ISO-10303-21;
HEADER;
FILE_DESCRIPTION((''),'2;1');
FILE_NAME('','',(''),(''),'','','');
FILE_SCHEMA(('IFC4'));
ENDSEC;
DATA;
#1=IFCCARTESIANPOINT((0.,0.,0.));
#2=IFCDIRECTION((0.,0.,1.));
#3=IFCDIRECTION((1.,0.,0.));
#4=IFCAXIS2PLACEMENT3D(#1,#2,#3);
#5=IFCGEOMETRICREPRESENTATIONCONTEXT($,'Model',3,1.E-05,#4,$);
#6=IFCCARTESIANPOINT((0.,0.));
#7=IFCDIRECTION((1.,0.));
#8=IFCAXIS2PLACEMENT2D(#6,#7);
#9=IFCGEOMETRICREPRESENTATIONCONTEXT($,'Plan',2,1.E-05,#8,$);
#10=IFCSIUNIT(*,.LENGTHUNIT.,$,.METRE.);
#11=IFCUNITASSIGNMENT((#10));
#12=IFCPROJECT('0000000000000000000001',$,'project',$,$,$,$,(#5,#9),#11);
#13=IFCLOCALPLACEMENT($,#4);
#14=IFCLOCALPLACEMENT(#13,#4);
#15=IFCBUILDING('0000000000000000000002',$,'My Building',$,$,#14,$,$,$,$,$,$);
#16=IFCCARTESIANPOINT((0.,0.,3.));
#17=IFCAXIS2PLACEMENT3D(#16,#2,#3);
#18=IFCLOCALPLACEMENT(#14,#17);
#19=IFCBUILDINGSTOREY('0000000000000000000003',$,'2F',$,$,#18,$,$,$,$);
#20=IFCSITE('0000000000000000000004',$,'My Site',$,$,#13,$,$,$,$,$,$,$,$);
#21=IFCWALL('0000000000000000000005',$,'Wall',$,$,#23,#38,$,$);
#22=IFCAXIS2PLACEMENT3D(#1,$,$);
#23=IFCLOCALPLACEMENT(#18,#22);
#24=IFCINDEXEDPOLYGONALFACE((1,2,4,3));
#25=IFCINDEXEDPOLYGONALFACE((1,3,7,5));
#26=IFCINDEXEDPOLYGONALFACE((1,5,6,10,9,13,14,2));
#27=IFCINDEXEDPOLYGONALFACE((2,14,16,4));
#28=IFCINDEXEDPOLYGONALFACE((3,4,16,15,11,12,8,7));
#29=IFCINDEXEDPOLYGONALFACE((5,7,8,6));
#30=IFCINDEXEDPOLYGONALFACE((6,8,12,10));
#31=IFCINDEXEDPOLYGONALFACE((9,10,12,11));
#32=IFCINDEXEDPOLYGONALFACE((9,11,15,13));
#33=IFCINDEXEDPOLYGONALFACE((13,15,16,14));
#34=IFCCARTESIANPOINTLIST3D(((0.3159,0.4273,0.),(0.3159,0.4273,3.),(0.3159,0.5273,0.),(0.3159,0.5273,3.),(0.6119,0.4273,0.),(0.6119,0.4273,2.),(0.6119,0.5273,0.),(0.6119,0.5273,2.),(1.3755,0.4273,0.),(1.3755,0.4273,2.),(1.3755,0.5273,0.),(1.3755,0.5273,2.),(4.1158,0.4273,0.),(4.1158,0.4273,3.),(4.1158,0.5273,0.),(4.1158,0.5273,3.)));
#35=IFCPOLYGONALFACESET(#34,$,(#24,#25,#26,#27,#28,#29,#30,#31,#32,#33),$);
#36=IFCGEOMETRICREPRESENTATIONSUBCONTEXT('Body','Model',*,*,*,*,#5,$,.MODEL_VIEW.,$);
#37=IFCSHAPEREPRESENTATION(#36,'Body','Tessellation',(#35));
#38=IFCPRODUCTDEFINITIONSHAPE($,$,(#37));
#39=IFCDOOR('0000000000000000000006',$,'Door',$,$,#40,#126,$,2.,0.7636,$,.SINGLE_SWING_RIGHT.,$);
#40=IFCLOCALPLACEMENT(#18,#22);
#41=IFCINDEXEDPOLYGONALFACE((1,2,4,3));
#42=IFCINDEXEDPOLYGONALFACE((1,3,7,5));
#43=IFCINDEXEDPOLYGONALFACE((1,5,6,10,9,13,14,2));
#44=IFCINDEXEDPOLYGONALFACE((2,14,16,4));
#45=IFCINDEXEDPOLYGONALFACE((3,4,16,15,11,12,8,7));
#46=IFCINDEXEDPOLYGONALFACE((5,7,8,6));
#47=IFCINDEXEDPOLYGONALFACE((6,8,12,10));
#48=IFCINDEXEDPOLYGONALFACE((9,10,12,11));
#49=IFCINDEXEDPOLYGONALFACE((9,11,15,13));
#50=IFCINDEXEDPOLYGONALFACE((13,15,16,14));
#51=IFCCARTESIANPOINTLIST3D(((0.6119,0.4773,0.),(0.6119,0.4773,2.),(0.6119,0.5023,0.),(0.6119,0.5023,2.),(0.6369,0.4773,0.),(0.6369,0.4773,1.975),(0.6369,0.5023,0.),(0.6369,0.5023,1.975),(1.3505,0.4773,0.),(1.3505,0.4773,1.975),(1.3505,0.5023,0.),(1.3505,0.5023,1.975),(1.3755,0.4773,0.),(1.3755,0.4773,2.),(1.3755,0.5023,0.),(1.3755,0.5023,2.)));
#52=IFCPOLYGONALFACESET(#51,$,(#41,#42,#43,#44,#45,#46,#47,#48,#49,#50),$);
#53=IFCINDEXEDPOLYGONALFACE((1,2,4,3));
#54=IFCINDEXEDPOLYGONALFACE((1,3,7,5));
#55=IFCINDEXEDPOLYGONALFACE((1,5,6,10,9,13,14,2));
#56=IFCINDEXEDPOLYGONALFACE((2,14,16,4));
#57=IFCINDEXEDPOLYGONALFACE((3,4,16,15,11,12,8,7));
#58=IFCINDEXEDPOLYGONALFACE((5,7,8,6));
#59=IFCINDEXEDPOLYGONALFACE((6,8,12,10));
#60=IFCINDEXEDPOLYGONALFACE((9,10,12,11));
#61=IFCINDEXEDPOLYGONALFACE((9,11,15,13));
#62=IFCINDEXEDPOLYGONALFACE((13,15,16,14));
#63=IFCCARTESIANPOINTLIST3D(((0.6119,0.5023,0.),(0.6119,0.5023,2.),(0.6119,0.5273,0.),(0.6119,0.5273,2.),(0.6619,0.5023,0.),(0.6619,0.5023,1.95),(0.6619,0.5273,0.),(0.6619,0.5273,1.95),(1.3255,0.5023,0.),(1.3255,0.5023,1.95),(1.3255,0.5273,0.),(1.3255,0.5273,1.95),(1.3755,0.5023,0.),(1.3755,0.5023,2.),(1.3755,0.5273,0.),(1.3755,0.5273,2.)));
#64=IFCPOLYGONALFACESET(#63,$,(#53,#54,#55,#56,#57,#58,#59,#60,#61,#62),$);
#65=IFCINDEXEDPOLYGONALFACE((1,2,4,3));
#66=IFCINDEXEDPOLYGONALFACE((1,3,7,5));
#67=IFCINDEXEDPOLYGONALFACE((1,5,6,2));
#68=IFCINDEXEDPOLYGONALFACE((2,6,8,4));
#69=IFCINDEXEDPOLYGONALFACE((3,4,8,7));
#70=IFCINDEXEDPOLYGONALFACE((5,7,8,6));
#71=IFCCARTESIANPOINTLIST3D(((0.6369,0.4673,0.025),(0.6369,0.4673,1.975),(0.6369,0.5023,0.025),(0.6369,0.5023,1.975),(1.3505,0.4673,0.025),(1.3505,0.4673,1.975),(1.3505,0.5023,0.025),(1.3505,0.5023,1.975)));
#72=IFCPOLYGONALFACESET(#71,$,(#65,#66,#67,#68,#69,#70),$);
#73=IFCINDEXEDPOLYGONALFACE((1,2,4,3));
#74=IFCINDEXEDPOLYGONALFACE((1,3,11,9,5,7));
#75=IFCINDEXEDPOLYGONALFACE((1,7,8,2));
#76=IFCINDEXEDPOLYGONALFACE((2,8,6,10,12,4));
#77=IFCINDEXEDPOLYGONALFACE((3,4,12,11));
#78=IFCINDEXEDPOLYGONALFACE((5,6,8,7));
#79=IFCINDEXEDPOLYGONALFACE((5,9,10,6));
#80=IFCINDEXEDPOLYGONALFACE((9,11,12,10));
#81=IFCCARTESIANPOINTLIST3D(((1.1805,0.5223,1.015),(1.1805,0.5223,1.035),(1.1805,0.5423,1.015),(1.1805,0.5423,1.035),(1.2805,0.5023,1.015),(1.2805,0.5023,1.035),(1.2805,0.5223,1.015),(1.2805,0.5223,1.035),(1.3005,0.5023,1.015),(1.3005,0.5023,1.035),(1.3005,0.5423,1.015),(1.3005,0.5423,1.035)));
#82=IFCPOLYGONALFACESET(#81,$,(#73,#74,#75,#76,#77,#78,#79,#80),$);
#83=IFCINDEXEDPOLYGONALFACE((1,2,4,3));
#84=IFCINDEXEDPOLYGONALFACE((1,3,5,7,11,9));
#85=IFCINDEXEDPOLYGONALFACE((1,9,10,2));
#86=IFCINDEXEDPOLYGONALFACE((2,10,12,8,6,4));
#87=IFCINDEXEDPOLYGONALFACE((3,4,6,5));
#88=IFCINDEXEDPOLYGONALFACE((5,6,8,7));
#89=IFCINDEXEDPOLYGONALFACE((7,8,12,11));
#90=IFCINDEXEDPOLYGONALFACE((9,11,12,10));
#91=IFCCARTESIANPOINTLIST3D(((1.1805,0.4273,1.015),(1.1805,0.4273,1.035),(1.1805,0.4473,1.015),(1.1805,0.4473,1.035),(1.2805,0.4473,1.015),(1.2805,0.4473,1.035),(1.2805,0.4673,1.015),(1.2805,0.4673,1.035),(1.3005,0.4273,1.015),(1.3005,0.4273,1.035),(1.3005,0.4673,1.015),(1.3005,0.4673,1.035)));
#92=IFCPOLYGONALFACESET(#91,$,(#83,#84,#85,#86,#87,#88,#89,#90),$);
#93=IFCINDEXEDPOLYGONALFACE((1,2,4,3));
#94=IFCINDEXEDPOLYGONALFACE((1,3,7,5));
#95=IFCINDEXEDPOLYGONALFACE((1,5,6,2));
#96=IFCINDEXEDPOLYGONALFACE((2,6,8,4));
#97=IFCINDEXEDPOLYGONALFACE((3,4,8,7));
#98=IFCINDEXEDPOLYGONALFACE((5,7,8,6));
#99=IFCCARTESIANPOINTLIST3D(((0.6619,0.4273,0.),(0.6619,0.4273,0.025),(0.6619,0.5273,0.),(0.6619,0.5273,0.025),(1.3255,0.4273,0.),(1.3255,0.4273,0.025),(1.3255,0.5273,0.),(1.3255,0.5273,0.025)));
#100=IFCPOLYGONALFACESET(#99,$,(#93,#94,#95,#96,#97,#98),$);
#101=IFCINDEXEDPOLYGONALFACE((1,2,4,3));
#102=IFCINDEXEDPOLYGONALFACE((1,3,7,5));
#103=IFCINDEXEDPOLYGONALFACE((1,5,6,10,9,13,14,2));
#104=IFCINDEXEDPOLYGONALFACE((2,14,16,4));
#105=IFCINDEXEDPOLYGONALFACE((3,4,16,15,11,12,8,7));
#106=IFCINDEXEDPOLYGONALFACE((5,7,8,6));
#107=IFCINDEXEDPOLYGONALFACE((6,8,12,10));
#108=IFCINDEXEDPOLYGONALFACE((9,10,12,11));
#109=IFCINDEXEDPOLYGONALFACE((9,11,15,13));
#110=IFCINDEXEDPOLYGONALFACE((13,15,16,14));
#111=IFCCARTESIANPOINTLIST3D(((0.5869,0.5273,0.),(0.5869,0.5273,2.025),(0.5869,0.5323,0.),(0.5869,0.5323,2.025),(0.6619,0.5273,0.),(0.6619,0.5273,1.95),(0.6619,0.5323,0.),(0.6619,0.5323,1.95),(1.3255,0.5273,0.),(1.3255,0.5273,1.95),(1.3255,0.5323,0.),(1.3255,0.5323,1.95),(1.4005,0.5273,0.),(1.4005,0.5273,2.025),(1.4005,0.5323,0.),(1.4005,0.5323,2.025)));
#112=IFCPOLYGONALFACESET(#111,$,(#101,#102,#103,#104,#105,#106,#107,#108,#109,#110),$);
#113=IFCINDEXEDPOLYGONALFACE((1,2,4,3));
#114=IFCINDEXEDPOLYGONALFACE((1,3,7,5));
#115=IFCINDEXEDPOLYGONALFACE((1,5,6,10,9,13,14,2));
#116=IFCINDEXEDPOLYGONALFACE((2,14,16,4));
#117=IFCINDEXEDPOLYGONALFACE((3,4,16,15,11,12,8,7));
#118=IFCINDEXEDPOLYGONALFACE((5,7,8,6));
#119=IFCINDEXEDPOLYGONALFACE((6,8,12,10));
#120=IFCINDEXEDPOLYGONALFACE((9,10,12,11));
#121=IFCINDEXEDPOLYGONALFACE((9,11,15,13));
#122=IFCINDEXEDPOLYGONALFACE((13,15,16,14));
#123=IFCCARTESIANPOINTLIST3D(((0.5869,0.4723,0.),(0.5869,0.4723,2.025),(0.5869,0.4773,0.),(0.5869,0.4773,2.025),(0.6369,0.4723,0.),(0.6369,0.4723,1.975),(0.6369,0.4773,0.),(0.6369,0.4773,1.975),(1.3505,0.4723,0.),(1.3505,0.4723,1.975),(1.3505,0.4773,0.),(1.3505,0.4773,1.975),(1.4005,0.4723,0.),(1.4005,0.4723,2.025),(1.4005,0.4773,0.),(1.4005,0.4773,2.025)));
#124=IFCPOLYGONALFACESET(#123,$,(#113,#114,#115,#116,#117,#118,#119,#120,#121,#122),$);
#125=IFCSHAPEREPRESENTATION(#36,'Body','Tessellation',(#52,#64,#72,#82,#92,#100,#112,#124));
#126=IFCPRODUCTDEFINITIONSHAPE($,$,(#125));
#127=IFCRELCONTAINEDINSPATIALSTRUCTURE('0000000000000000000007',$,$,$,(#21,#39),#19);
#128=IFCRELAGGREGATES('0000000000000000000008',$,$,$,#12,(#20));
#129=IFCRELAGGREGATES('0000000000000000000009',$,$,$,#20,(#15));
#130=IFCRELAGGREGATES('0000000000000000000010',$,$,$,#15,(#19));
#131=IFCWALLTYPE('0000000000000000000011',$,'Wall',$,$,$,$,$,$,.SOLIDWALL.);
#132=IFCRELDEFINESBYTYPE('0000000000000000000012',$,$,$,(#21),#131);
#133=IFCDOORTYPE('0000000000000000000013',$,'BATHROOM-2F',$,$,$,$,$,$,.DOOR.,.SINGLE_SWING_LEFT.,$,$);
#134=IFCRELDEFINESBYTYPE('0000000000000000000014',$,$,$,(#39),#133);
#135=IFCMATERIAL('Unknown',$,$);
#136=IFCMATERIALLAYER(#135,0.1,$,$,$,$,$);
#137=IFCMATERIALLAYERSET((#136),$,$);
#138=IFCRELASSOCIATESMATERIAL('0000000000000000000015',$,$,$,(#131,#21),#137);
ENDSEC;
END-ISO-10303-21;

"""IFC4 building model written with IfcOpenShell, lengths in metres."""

from ifc_helpers import new_model, entity, si_unit, frame, origin_with_axes, origin_2d_with_axis, place, context, subcontext, project, spatial, line, indexed_curve, outline, extrude, shape, source, transform, mapped, material, layer, layer_set, layer_usage, type_object, type_shapes, element, fill, save


model = new_model("IFC4")

# Units and contexts
model_context = context("Model", 3, precision=1e-05, world=origin_with_axes())
plan_context = context("Plan", 2, precision=1e-05, world=origin_2d_with_axis())
body_context_1 = subcontext(model_context, "Body", "Model", "MODEL_VIEW")
body_context_2 = subcontext(plan_context, "Body", "Plan", "PLAN_VIEW")
ifc_project = project(units=[si_unit("LENGTHUNIT", "METRE")], contexts=[model_context, plan_context])

# Site, building, storey
site_placement = place(None, origin_with_axes())
site = spatial("IfcSite", under=ifc_project, at=site_placement, Name="My Site")
building_placement = place(site_placement, origin_with_axes())
building = spatial("IfcBuilding", under=site, at=building_placement, Name="My Building")
storey_placement = place(building_placement, frame((0.0, 0.0, 3.0), z_axis=(0.0, 0.0, 1.0), x_axis=(1.0, 0.0, 0.0)))
storey = spatial("IfcBuildingStorey", under=building, at=storey_placement, Name="2F")

# Shared definitions
ifc_material = material(Name="Unknown")

# Shared definitions
ifc_layer_1 = layer(ifc_material, 0.1)
ifc_layer_set_1 = layer_set([ifc_layer_1])
wall_type = type_object("IfcWallType", Name="Wall", PredefinedType="SOLIDWALL", material=ifc_layer_set_1)

# Wall, opening, door
ifc_layer_usage_1 = layer_usage(ifc_layer_set_1, "AXIS2", "POSITIVE", 0.0)
wall_1_placement = place(storey_placement, frame((0.3159, 0.4273, 0.0), z_axis=(0.0, 0.0, 1.0), x_axis=(1.0, 0.0, 0.0)))
wall_1 = element("IfcWall", 1, at=wall_1_placement, inside=storey, type_object=wall_type, material=ifc_layer_usage_1, Name="Wall", context=body_context_1, shape_type="SweptSolid", body=[
    extrude(outline(indexed_curve([(0.0, 0.0), (0.0, 0.1), (3.8, 0.1), (3.8, 0.0)], segments=[line(1, 2, 3, 4, 1)])), origin_with_axes(), (0.0, 0.0, 1.0), 3.0),
])
shared_shape_1 = source(origin_with_axes(), body_context_1, "Body", "SweptSolid", [
    extrude(outline(indexed_curve([(0.0, 0.0), (0.7636, 0.0), (0.7636, 2.0), (0.0, 2.0)], segments=[line(1, 2, 3, 4, 1)])), frame((0.0, -0.6, 0.0), z_axis=(0.0, -1.0, 0.0), x_axis=(1.0, 0.0, 0.0)), (0.0, 0.0, -1.0), 1.2),
])
opening_1_placement = place(wall_1_placement, frame((1.0596, 0.1, 0.0), z_axis=(0.0, 0.0, 1.0), x_axis=(-1.0, 0.0, 0.0)))
opening_1 = element("IfcOpeningElement", 2, at=opening_1_placement, cuts=wall_1, PredefinedType="OPENING", context=body_context_1, shape_type="MappedRepresentation", body=[
    mapped(shared_shape_1, transform((0.0, 0.0, 0.0), x_axis=(1.0, 0.0, 0.0), y_axis=(0.0, 1.0, 0.0), z_axis=(0.0, 0.0, 1.0), scale=1.0)),
])
door_type_1 = type_object("IfcDoorType", Name="BATHROOM-2F", OperationType="SINGLE_SWING_LEFT", PredefinedType="DOOR")
shared_shape_2 = source(origin_with_axes(), body_context_1, "Body", "SweptSolid", [
    extrude(outline(indexed_curve([(0.0, 0.0), (0.0, 2.0), (0.7636, 2.0), (0.7636, 0.0), (0.7386, 0.0), (0.7386, 1.975), (0.025, 1.975), (0.025, 0.0)], segments=[line(1, 2, 3, 4, 5, 6, 7, 8, 1)])), frame((0.0, 0.025, 0.0), z_axis=(0.0, -1.0, 0.0), x_axis=(1.0, 0.0, 0.0)), (0.0, 0.0, -1.0), 0.025),
    extrude(outline(indexed_curve([(0.0, 0.0), (0.0, 2.0), (0.7636, 2.0), (0.7636, 0.0), (0.7136, 0.0), (0.7136, 1.95), (0.05, 1.95), (0.05, 0.0)], segments=[line(1, 2, 3, 4, 5, 6, 7, 8, 1)])), frame((0.0, 0.0, 0.0), z_axis=(0.0, -1.0, 0.0), x_axis=(1.0, 0.0, 0.0)), (0.0, 0.0, -1.0), 0.025),
    extrude(outline(indexed_curve([(0.0, 0.0), (0.7136, 0.0), (0.7136, 0.035), (0.0, 0.035)], segments=[line(1, 2, 3, 4, 1)])), frame((0.025, 0.025, 0.025), z_axis=(0.0, 0.0, 1.0), x_axis=(1.0, 0.0, 0.0)), (0.0, 0.0, 1.0), 1.95),
    extrude(outline(indexed_curve([(0.0, 0.0), (0.0, -0.04), (0.12, -0.04), (0.12, -0.02), (0.02, -0.02), (0.02, 0.0)], segments=[line(1, 2, 3, 4, 5, 6, 1)])), frame((0.075, 0.025, 1.015), z_axis=(0.0, 0.0, 1.0), x_axis=(1.0, 0.0, 0.0)), (0.0, 0.0, 1.0), 0.02),
    extrude(outline(indexed_curve([(0.0, 0.0), (0.0, 0.04), (0.12, 0.04), (0.12, 0.02), (0.02, 0.02), (0.02, 0.0)], segments=[line(1, 2, 3, 4, 5, 6, 1)])), frame((0.075, 0.06, 1.015), z_axis=(0.0, 0.0, 1.0), x_axis=(1.0, 0.0, 0.0)), (0.0, 0.0, 1.0), 0.02),
    extrude(outline(indexed_curve([(0.0, 0.0), (0.6636, 0.0), (0.6636, 0.1), (0.0, 0.1)], segments=[line(1, 2, 3, 4, 1)])), frame((0.05, 0.0, 0.0), z_axis=(0.0, 0.0, 1.0), x_axis=(1.0, 0.0, 0.0)), (0.0, 0.0, 1.0), 0.025),
    extrude(outline(indexed_curve([(0.0, 0.0), (0.0, 2.025), (0.8136, 2.025), (0.8136, 0.0), (0.7386, 0.0), (0.7386, 1.95), (0.075, 1.95), (0.075, 0.0)], segments=[line(1, 2, 3, 4, 5, 6, 7, 8, 1)])), frame((-0.025, -0.005, 0.0), z_axis=(0.0, -1.0, 0.0), x_axis=(1.0, 0.0, 0.0)), (0.0, 0.0, -1.0), 0.005),
    extrude(outline(indexed_curve([(0.0, 0.0), (0.0, 2.025), (0.8136, 2.025), (0.8136, 0.0), (0.7636, 0.0), (0.7636, 1.975), (0.05, 1.975), (0.05, 0.0)], segments=[line(1, 2, 3, 4, 5, 6, 7, 8, 1)])), frame((-0.025, 0.05, 0.0), z_axis=(0.0, -1.0, 0.0), x_axis=(1.0, 0.0, 0.0)), (0.0, 0.0, -1.0), 0.005),
])
shared_shape_3 = source(origin_with_axes(), body_context_2, "Body", "Curve2D", [
    entity("IfcIndexedPolyCurve", entity("IfcCartesianPointList2D", [[0.0, 0.0], [0.0, 0.05], [0.025, 0.05], [0.025, 0.025], [0.05, 0.025], [0.05, 0.0]]), [entity("IfcLineIndex", [1, 2, 3, 4, 5, 6, 1])]),
    entity("IfcIndexedPolyCurve", entity("IfcCartesianPointList2D", [[0.7636, 0.0], [0.7636, 0.05], [0.7386, 0.05], [0.7386, 0.025], [0.7136, 0.025], [0.7136, 0.0]]), [entity("IfcLineIndex", [1, 2, 3, 4, 5, 6, 1])]),
    entity("IfcTrimmedCurve", entity("IfcEllipse", entity("IfcAxis2Placement2D", entity("IfcCartesianPoint", [0.7036, 0.05]), entity("IfcDirection", [1.0, 0.0])), 0.6786, 0.7136), [entity("IfcCartesianPoint", [0.7036, 0.7636])], [entity("IfcCartesianPoint", [0.025, 0.05])], True, "CARTESIAN"),
    entity("IfcIndexedPolyCurve", entity("IfcCartesianPointList2D", [[0.7386, 0.05], [0.7036, 0.05], [0.7036, 0.7636], [0.7386, 0.7636]]), [entity("IfcLineIndex", [1, 2, 3, 4, 1])]),
])
type_shapes(door_type_1, [shared_shape_2, shared_shape_3])
door_1_placement = place(opening_1_placement, frame((0.0, 0.0, 0.0), z_axis=(0.0, 0.0, 1.0), x_axis=(1.0, 0.0, 0.0)))
door_1 = element("IfcDoor", 3, at=door_1_placement, inside=storey, type_object=door_type_1, Name="Door", OperationType="SINGLE_SWING_RIGHT", OverallHeight=2.0, OverallWidth=0.7636, shapes=[
    shape(body_context_1, "Body", "MappedRepresentation", [mapped(shared_shape_2, transform((0.0, 0.0, 0.0), x_axis=(1.0, 0.0, 0.0), y_axis=(0.0, 1.0, 0.0), z_axis=(0.0, 0.0, 1.0), scale=1.0))]),
    shape(body_context_2, "Body", "MappedRepresentation", [mapped(shared_shape_3, transform((0.0, 0.0, 0.0), x_axis=(1.0, 0.0, 0.0), y_axis=(0.0, 1.0, 0.0), z_axis=(0.0, 0.0, 1.0), scale=1.0))]),
])
fill(opening_1, door_1)

save(model, "model.ifc")
